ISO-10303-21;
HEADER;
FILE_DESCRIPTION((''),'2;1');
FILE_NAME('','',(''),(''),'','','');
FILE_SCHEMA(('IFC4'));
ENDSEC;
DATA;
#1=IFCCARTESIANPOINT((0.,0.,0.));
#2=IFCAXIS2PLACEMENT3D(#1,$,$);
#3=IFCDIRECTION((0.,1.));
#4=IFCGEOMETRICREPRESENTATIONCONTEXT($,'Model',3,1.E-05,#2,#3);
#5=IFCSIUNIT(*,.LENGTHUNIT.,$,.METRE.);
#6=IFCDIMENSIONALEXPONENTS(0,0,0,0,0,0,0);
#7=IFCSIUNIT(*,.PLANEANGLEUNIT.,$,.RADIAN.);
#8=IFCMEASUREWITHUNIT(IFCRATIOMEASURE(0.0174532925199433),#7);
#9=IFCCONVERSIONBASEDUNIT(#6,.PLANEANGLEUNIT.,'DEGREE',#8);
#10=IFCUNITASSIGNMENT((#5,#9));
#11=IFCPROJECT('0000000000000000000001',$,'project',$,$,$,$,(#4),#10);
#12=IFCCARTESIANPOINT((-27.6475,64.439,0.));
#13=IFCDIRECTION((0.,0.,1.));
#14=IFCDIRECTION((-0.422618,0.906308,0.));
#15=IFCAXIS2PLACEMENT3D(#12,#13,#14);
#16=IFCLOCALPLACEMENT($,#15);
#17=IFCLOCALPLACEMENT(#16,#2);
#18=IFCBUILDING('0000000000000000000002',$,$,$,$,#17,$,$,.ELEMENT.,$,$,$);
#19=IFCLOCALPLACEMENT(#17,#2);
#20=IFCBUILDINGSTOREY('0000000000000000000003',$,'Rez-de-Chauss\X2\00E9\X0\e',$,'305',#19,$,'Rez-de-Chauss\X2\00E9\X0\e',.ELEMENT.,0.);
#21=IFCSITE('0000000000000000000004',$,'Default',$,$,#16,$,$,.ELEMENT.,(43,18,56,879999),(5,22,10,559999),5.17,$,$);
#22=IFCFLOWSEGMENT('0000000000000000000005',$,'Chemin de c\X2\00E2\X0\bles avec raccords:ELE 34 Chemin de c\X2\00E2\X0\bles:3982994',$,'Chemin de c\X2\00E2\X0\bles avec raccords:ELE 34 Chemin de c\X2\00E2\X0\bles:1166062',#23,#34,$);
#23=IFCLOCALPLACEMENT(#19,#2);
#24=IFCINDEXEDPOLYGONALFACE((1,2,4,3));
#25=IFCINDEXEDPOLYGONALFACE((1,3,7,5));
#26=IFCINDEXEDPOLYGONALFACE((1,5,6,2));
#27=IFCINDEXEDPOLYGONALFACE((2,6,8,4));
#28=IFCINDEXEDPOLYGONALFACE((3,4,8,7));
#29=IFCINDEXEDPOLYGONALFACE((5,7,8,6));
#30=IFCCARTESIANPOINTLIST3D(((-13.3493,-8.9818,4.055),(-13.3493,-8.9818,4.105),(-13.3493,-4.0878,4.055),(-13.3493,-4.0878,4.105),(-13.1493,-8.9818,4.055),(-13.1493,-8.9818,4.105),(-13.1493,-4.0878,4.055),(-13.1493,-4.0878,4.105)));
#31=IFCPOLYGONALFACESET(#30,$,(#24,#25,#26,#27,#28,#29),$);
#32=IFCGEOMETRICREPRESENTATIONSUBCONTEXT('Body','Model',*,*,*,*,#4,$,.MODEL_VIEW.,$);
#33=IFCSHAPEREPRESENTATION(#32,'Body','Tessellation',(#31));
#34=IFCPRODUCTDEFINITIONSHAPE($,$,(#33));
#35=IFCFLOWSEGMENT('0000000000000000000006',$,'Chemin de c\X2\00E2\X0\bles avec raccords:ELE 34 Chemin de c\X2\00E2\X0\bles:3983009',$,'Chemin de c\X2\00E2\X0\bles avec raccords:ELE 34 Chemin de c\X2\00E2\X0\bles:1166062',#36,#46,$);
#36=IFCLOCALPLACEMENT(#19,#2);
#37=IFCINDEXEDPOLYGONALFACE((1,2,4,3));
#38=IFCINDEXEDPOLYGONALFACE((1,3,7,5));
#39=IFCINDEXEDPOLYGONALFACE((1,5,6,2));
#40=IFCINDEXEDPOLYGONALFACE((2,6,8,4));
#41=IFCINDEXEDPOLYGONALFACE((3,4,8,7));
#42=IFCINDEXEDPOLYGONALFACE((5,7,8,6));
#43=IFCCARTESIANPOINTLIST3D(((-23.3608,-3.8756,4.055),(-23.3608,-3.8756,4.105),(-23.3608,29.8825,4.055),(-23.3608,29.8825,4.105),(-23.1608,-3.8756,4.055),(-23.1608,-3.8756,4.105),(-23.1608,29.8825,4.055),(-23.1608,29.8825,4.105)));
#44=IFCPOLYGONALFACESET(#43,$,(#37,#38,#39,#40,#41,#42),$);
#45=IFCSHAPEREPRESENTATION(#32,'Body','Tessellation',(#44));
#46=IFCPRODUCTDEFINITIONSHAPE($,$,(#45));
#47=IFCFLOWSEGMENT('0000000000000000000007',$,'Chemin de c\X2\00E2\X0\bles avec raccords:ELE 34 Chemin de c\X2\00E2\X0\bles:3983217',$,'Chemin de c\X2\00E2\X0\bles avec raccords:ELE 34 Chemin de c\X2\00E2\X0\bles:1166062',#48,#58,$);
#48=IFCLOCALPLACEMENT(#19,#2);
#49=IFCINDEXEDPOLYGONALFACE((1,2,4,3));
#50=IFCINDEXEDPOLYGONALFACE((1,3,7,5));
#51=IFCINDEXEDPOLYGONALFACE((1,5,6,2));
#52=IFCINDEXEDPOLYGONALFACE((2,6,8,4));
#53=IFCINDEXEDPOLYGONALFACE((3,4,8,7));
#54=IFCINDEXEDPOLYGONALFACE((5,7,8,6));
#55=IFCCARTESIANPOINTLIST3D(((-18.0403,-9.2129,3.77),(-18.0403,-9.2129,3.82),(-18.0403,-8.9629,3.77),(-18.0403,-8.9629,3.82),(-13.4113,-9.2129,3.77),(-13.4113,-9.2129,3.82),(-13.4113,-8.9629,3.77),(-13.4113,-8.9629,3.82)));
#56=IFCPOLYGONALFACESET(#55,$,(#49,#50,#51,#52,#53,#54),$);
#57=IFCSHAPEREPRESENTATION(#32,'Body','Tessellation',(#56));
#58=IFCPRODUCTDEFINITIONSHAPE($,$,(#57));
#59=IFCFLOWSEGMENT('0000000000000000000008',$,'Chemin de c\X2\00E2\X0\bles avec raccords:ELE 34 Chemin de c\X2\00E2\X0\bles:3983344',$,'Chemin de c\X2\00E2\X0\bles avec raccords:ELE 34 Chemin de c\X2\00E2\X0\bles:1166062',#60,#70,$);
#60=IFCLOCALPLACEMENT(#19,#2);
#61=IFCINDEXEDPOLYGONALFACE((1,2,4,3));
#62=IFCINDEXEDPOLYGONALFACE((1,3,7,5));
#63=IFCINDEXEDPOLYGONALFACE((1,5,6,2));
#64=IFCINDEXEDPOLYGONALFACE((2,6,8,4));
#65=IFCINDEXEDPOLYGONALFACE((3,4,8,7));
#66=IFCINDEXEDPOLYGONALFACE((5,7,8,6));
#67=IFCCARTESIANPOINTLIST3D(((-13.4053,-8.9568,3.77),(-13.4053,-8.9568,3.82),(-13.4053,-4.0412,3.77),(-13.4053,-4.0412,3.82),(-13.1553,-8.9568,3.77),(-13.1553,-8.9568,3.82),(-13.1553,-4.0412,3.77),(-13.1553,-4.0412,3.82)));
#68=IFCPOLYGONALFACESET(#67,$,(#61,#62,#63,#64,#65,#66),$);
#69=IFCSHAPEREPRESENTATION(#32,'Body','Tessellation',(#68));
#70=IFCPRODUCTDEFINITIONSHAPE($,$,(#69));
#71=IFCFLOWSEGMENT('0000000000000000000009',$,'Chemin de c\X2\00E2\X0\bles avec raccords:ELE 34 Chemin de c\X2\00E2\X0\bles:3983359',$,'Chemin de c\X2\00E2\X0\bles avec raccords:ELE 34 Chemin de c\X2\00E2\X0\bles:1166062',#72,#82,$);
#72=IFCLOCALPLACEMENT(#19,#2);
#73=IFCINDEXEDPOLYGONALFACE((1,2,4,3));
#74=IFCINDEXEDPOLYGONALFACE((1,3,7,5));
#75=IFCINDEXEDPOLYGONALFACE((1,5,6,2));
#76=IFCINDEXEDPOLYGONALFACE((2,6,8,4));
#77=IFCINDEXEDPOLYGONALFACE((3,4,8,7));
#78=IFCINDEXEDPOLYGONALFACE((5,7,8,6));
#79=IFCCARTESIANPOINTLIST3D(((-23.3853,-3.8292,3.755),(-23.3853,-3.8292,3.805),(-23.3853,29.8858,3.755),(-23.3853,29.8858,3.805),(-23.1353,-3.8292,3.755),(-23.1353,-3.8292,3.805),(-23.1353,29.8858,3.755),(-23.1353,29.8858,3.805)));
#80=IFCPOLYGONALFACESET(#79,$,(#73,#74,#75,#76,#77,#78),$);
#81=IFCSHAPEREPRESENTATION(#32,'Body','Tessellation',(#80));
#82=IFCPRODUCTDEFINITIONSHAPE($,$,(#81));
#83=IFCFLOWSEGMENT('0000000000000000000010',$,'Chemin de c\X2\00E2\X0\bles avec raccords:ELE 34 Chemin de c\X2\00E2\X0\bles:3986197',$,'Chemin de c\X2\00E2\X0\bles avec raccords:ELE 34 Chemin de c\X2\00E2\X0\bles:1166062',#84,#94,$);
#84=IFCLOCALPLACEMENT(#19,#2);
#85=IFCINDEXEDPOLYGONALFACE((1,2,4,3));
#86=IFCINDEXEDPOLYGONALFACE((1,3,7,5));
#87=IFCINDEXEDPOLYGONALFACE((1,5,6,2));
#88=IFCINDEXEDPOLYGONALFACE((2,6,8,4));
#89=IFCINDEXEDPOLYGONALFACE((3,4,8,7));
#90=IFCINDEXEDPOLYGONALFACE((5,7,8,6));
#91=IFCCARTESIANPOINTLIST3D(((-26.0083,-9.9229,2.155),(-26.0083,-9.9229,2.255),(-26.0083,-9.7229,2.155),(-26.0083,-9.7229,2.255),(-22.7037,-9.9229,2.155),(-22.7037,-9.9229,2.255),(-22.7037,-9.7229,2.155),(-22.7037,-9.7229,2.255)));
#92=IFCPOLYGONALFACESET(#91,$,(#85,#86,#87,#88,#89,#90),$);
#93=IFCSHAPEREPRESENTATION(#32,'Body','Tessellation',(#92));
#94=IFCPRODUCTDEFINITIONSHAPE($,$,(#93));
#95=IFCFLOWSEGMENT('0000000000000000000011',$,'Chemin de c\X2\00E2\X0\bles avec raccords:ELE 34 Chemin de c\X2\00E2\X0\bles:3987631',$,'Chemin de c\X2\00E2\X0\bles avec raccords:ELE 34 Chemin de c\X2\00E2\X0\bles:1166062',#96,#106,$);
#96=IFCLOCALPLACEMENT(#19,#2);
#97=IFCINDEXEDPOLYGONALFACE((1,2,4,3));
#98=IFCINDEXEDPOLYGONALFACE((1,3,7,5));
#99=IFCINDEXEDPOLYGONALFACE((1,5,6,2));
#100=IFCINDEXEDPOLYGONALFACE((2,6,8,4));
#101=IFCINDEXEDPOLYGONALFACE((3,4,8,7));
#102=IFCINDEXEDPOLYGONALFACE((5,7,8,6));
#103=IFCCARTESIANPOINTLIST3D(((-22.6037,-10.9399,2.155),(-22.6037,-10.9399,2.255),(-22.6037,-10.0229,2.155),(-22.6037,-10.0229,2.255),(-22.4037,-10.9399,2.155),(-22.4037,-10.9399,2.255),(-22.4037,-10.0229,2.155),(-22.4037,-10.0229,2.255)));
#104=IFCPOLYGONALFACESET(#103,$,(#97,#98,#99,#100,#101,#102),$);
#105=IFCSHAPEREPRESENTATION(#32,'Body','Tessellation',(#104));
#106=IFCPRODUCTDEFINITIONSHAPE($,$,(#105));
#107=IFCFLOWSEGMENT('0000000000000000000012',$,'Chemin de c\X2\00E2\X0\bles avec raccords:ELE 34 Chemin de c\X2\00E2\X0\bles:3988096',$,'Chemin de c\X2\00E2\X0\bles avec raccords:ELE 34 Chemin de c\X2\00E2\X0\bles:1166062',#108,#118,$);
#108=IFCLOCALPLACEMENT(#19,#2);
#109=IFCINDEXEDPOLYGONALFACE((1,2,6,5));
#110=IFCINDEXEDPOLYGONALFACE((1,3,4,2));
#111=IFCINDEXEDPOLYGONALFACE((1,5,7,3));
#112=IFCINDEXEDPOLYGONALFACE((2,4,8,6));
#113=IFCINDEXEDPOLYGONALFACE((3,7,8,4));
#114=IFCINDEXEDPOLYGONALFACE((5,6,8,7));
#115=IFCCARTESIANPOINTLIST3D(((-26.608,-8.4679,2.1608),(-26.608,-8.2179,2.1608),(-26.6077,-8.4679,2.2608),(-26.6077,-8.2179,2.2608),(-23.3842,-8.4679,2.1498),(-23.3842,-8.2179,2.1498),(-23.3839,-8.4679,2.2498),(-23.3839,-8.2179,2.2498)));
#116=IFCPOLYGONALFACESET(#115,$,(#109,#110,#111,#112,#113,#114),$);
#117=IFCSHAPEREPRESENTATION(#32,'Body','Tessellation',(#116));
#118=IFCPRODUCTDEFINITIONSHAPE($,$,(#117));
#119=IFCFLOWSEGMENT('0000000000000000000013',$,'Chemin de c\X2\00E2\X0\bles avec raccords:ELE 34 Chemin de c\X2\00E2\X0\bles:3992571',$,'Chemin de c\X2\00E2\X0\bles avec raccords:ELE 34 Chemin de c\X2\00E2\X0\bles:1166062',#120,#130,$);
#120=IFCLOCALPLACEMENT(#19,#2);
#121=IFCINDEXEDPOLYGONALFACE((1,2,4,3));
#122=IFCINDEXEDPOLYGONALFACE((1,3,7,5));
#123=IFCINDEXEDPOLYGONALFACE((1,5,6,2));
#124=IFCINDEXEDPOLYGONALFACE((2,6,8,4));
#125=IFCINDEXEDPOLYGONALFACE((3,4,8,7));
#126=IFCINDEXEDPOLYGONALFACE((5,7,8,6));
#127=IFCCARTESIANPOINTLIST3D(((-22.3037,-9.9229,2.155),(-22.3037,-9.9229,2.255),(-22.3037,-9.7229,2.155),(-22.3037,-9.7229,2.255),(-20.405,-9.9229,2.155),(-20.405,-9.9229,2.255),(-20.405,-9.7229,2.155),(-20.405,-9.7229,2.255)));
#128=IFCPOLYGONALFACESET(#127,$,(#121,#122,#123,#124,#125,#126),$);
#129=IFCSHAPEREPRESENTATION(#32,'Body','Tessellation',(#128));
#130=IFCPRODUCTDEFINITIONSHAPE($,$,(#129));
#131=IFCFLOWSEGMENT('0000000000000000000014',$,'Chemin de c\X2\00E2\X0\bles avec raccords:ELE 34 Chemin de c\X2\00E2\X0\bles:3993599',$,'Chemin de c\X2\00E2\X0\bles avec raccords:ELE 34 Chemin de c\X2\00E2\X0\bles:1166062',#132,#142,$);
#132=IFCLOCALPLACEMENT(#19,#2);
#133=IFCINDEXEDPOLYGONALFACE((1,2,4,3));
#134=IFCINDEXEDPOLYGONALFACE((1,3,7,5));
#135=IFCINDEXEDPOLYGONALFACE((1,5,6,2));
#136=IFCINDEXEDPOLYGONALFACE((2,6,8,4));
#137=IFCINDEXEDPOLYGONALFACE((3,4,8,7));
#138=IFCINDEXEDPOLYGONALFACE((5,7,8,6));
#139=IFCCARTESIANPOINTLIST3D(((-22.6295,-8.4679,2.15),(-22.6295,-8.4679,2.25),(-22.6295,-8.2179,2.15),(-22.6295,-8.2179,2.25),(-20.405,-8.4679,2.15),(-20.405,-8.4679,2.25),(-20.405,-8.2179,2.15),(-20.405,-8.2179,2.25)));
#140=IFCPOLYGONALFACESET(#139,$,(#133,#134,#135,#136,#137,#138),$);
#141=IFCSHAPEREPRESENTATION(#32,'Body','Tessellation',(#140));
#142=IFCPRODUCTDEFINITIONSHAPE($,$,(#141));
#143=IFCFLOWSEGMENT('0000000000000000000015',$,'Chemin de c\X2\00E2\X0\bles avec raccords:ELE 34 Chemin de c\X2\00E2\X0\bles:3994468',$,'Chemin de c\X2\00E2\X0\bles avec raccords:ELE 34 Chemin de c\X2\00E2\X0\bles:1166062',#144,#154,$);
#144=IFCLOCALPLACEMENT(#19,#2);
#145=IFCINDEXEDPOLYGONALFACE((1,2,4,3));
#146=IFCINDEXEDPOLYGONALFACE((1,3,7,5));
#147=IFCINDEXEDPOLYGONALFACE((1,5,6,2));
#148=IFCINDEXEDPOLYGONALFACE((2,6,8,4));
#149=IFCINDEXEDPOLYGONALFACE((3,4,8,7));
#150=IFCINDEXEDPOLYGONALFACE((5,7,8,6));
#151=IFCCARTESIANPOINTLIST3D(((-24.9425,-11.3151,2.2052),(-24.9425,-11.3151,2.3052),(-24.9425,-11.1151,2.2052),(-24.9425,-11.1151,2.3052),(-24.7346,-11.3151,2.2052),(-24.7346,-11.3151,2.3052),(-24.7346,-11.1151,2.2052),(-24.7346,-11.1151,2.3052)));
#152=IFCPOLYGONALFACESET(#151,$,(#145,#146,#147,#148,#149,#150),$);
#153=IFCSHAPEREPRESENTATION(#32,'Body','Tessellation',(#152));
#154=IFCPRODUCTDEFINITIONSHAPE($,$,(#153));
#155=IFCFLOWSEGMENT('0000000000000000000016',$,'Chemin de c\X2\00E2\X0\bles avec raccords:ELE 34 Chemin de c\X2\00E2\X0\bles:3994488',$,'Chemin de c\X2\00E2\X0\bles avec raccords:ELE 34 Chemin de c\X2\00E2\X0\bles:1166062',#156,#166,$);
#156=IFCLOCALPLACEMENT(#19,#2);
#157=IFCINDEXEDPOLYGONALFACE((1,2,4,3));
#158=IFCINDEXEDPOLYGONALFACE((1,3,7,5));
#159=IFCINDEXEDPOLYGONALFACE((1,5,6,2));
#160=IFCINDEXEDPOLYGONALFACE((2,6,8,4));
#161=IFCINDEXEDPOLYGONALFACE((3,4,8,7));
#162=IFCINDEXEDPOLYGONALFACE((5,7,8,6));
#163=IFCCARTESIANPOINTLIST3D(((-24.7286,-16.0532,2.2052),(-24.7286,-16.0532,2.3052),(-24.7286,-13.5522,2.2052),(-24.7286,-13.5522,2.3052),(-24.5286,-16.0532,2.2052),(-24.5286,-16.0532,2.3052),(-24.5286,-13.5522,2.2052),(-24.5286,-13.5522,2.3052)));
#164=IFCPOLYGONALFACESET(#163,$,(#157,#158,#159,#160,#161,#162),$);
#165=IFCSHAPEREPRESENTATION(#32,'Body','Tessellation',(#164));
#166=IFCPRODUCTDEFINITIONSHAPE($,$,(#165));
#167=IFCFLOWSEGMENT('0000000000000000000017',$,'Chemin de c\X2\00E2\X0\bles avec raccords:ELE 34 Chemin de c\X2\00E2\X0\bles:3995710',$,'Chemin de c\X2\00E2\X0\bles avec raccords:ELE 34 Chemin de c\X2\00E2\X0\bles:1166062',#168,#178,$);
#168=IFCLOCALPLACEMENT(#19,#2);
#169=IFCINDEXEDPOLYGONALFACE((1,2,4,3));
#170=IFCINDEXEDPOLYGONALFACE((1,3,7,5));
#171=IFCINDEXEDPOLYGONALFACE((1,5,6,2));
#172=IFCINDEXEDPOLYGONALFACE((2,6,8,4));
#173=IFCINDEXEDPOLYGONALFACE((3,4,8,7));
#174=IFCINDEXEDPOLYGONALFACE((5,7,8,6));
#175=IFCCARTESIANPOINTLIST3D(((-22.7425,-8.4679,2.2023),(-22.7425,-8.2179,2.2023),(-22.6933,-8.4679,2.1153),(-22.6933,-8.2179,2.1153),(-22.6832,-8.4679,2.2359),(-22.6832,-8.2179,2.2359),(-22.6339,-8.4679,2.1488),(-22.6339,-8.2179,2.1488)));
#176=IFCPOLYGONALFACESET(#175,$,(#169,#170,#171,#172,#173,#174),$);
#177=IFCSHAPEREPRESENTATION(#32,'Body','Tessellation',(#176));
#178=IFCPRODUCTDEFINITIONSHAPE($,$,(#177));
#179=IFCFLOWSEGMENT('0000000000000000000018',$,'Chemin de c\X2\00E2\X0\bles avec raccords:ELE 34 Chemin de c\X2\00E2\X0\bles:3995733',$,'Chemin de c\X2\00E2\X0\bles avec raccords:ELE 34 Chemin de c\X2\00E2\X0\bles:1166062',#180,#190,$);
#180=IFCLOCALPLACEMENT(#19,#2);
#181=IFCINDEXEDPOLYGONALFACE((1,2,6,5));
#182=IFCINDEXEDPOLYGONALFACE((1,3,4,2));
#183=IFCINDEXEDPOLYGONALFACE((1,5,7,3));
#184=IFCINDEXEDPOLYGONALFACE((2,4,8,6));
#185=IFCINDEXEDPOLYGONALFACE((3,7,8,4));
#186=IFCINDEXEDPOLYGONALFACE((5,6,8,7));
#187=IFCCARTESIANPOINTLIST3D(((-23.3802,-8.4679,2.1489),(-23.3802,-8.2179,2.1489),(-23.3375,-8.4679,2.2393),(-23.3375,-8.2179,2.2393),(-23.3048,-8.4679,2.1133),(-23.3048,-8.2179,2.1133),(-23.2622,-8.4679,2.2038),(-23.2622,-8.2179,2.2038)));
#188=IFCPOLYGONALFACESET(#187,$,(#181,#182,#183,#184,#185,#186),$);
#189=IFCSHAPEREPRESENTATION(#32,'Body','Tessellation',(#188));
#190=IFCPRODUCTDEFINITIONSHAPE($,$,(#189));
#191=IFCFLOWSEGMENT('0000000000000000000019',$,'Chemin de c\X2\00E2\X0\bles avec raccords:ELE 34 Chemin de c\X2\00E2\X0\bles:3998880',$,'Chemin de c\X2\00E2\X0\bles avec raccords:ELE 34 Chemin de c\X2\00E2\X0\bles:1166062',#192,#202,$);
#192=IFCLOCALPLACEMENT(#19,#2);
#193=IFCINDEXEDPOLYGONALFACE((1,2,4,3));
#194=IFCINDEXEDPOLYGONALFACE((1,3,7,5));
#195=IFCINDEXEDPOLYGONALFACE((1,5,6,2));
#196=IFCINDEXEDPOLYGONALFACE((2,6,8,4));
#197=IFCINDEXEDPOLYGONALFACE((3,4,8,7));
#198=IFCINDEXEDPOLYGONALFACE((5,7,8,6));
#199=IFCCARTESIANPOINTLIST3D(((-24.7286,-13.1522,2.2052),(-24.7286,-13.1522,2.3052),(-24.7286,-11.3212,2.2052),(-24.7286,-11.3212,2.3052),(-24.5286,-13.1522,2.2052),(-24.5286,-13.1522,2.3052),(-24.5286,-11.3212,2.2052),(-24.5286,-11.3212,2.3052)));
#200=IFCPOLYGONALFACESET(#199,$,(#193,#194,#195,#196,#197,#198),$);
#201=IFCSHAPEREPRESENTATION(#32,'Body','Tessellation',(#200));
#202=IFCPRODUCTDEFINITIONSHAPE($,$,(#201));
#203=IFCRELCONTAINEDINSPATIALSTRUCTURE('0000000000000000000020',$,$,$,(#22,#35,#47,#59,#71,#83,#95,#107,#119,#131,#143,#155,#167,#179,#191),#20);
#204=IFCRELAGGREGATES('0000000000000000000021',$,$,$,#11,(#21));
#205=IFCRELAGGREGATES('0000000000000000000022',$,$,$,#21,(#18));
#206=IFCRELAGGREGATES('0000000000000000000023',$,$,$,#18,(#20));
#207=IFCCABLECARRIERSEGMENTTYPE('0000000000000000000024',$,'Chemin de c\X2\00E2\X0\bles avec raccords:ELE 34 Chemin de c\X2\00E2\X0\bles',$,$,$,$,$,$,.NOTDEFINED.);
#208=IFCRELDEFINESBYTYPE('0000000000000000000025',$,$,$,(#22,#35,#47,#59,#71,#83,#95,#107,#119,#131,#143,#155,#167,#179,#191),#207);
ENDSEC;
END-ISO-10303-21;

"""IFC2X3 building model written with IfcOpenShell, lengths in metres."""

from ifc_helpers import new_model, entity, si_unit, converted_unit, direction, frame, frame_2d, origin, origin_2d_with_axis, place, context, subcontext, project, spatial, rectangle, extrude, type_object, element, save


model = new_model("IFC2X3")

# Units and contexts
model_context = context("Model", 3, precision=1e-05, world=origin(), true_north=direction((0.0, 1.0)))
body_context = subcontext(model_context, "Body", "Model", "MODEL_VIEW")
ifc_project = project(units=[si_unit("LENGTHUNIT", "METRE"), converted_unit("PLANEANGLEUNIT", "DEGREE", entity("IfcRatioMeasure", 0.0174532925199433), si_unit("PLANEANGLEUNIT", "RADIAN"), dimensions=[0, 0, 0, 0, 0, 0, 0])], contexts=[model_context])

# Site, building, storey
site_placement = place(None, frame((-27.6475, 64.439, 0.0), z_axis=(0.0, 0.0, 1.0), x_axis=(-0.422618, 0.906308, 0.0)))
site = spatial("IfcSite", under=ifc_project, at=site_placement, Name="Default", CompositionType="ELEMENT", RefLatitude=(43, 18, 56, 879999), RefLongitude=(5, 22, 10, 559999), RefElevation=5.17)
building_placement = place(site_placement, origin())
building = spatial("IfcBuilding", under=site, at=building_placement, CompositionType="ELEMENT")
storey_placement = place(building_placement, origin())
storey = spatial("IfcBuildingStorey", under=building, at=storey_placement, Name="Rez-de-Chaussée", ObjectType="305", LongName="Rez-de-Chaussée", CompositionType="ELEMENT", Elevation=0.0)

# Flow segments
cable_carrier_segment_type = type_object("IfcCableCarrierSegmentType", Name="Chemin de câbles avec raccords:ELE 34 Chemin de câbles", PredefinedType="NOTDEFINED")
flow_segment_1_placement = place(storey_placement, origin())
element("IfcFlowSegment", 1, at=flow_segment_1_placement, inside=storey, type_object=cable_carrier_segment_type, Name="Chemin de câbles avec raccords:ELE 34 Chemin de câbles:3982994", ObjectType="Chemin de câbles avec raccords:ELE 34 Chemin de câbles:1166062", context=body_context, shape_type="SweptSolid", body=[
    extrude(rectangle(XDim=4.8941, YDim=0.2, at=frame_2d((0.0, 0.0), x_axis=(1.0, 0.0))), frame((-13.2493, -6.5348, 4.055), z_axis=(0.0, 0.0, 1.0), x_axis=(0.0, -1.0, 0.0)), (0.0, 0.0, 1.0), 0.05),
])
flow_segment_2_placement = place(storey_placement, origin())
element("IfcFlowSegment", 2, at=flow_segment_2_placement, inside=storey, type_object=cable_carrier_segment_type, Name="Chemin de câbles avec raccords:ELE 34 Chemin de câbles:3983009", ObjectType="Chemin de câbles avec raccords:ELE 34 Chemin de câbles:1166062", context=body_context, shape_type="SweptSolid", body=[
    extrude(rectangle(XDim=33.7581, YDim=0.2, at=origin_2d_with_axis()), frame((-23.2608, 13.0034, 4.055), z_axis=(0.0, 0.0, 1.0), x_axis=(0.0, 1.0, 0.0)), (0.0, 0.0, 1.0), 0.05),
])
flow_segment_3_placement = place(storey_placement, origin())
element("IfcFlowSegment", 3, at=flow_segment_3_placement, inside=storey, type_object=cable_carrier_segment_type, Name="Chemin de câbles avec raccords:ELE 34 Chemin de câbles:3983217", ObjectType="Chemin de câbles avec raccords:ELE 34 Chemin de câbles:1166062", context=body_context, shape_type="SweptSolid", body=[
    extrude(rectangle(XDim=4.629, YDim=0.25, at=frame_2d((0.0, 0.0), x_axis=(1.0, 0.0))), frame((-15.7258, -9.0879, 3.77), z_axis=(0.0, 0.0, 1.0), x_axis=(-1.0, 0.0, 0.0)), (0.0, 0.0, 1.0), 0.05),
])
flow_segment_4_placement = place(storey_placement, origin())
element("IfcFlowSegment", 4, at=flow_segment_4_placement, inside=storey, type_object=cable_carrier_segment_type, Name="Chemin de câbles avec raccords:ELE 34 Chemin de câbles:3983344", ObjectType="Chemin de câbles avec raccords:ELE 34 Chemin de câbles:1166062", context=body_context, shape_type="SweptSolid", body=[
    extrude(rectangle(XDim=4.9156, YDim=0.25, at=frame_2d((0.0, 0.0), x_axis=(1.0, 0.0))), frame((-13.2803, -6.499, 3.77), z_axis=(0.0, 0.0, 1.0), x_axis=(0.0, 1.0, 0.0)), (0.0, 0.0, 1.0), 0.05),
])
flow_segment_5_placement = place(storey_placement, origin())
element("IfcFlowSegment", 5, at=flow_segment_5_placement, inside=storey, type_object=cable_carrier_segment_type, Name="Chemin de câbles avec raccords:ELE 34 Chemin de câbles:3983359", ObjectType="Chemin de câbles avec raccords:ELE 34 Chemin de câbles:1166062", context=body_context, shape_type="SweptSolid", body=[
    extrude(rectangle(XDim=33.715, YDim=0.25, at=frame_2d((0.0, 0.0), x_axis=(1.0, 0.0))), frame((-23.2603, 13.0283, 3.755), z_axis=(0.0, 0.0, 1.0), x_axis=(0.0, 1.0, 0.0)), (0.0, 0.0, 1.0), 0.05),
])
flow_segment_6_placement = place(storey_placement, origin())
element("IfcFlowSegment", 6, at=flow_segment_6_placement, inside=storey, type_object=cable_carrier_segment_type, Name="Chemin de câbles avec raccords:ELE 34 Chemin de câbles:3986197", ObjectType="Chemin de câbles avec raccords:ELE 34 Chemin de câbles:1166062", context=body_context, shape_type="SweptSolid", body=[
    extrude(rectangle(XDim=3.3046, YDim=0.2, at=frame_2d((0.0, 0.0), x_axis=(1.0, 0.0))), frame((-24.356, -9.8229, 2.155), z_axis=(0.0, 0.0, 1.0), x_axis=(-1.0, 0.0, 0.0)), (0.0, 0.0, 1.0), 0.1),
])
flow_segment_7_placement = place(storey_placement, origin())
element("IfcFlowSegment", 7, at=flow_segment_7_placement, inside=storey, type_object=cable_carrier_segment_type, Name="Chemin de câbles avec raccords:ELE 34 Chemin de câbles:3987631", ObjectType="Chemin de câbles avec raccords:ELE 34 Chemin de câbles:1166062", context=body_context, shape_type="SweptSolid", body=[
    extrude(rectangle(XDim=0.917, YDim=0.2, at=origin_2d_with_axis()), frame((-22.5037, -10.4814, 2.155), z_axis=(0.0, 0.0, 1.0), x_axis=(0.0, -1.0, 0.0)), (0.0, 0.0, 1.0), 0.1),
])
flow_segment_8_placement = place(storey_placement, origin())
element("IfcFlowSegment", 8, at=flow_segment_8_placement, inside=storey, type_object=cable_carrier_segment_type, Name="Chemin de câbles avec raccords:ELE 34 Chemin de câbles:3988096", ObjectType="Chemin de câbles avec raccords:ELE 34 Chemin de câbles:1166062", context=body_context, shape_type="SweptSolid", body=[
    extrude(rectangle(XDim=3.2238, YDim=0.25, at=frame_2d((0.0, 0.0), x_axis=(1.0, 0.0))), frame((-24.9961, -8.3429, 2.1553), z_axis=(0.003393, 0.0, 0.999994), x_axis=(-0.999994, 0.0, 0.003393)), (0.0, 0.0, 1.0), 0.1),
])
flow_segment_9_placement = place(storey_placement, origin())
element("IfcFlowSegment", 9, at=flow_segment_9_placement, inside=storey, type_object=cable_carrier_segment_type, Name="Chemin de câbles avec raccords:ELE 34 Chemin de câbles:3992571", ObjectType="Chemin de câbles avec raccords:ELE 34 Chemin de câbles:1166062", context=body_context, shape_type="SweptSolid", body=[
    extrude(rectangle(XDim=1.8987, YDim=0.2, at=frame_2d((0.0, 0.0), x_axis=(1.0, 0.0))), frame((-21.3544, -9.8229, 2.155)), (0.0, 0.0, 1.0), 0.1),
])
flow_segment_10_placement = place(storey_placement, origin())
element("IfcFlowSegment", 10, at=flow_segment_10_placement, inside=storey, type_object=cable_carrier_segment_type, Name="Chemin de câbles avec raccords:ELE 34 Chemin de câbles:3993599", ObjectType="Chemin de câbles avec raccords:ELE 34 Chemin de câbles:1166062", context=body_context, shape_type="SweptSolid", body=[
    extrude(rectangle(XDim=2.2245, YDim=0.25, at=frame_2d((0.0, 0.0), x_axis=(1.0, 0.0))), frame((-21.5173, -8.3429, 2.15)), (0.0, 0.0, 1.0), 0.1),
])
flow_segment_11_placement = place(storey_placement, origin())
element("IfcFlowSegment", 11, at=flow_segment_11_placement, inside=storey, type_object=cable_carrier_segment_type, Name="Chemin de câbles avec raccords:ELE 34 Chemin de câbles:3994468", ObjectType="Chemin de câbles avec raccords:ELE 34 Chemin de câbles:1166062", context=body_context, shape_type="SweptSolid", body=[
    extrude(rectangle(XDim=0.2078, YDim=0.2, at=frame_2d((0.0, 0.0), x_axis=(1.0, 0.0))), frame((-24.8386, -11.2151, 2.2052)), (0.0, 0.0, 1.0), 0.1),
])
flow_segment_12_placement = place(storey_placement, origin())
element("IfcFlowSegment", 12, at=flow_segment_12_placement, inside=storey, type_object=cable_carrier_segment_type, Name="Chemin de câbles avec raccords:ELE 34 Chemin de câbles:3994488", ObjectType="Chemin de câbles avec raccords:ELE 34 Chemin de câbles:1166062", context=body_context, shape_type="SweptSolid", body=[
    extrude(rectangle(XDim=2.5009, YDim=0.2, at=frame_2d((0.0, 0.0), x_axis=(1.0, 0.0))), frame((-24.6286, -14.8027, 2.2052), z_axis=(0.0, 0.0, 1.0), x_axis=(0.0, -1.0, 0.0)), (0.0, 0.0, 1.0), 0.1),
])
flow_segment_13_placement = place(storey_placement, origin())
element("IfcFlowSegment", 13, at=flow_segment_13_placement, inside=storey, type_object=cable_carrier_segment_type, Name="Chemin de câbles avec raccords:ELE 34 Chemin de câbles:3995710", ObjectType="Chemin de câbles avec raccords:ELE 34 Chemin de câbles:1166062", context=body_context, shape_type="SweptSolid", body=[
    extrude(rectangle(XDim=0.1, YDim=0.0682, at=frame_2d((0.0, 0.0), x_axis=(0.0, 1.0))), frame((-22.6882, -8.4679, 2.1756), z_axis=(0.0, 1.0, 0.0), x_axis=(0.870359, 0.0, 0.492418)), (0.0, 0.0, 1.0), 0.25),
])
flow_segment_14_placement = place(storey_placement, origin())
element("IfcFlowSegment", 14, at=flow_segment_14_placement, inside=storey, type_object=cable_carrier_segment_type, Name="Chemin de câbles avec raccords:ELE 34 Chemin de câbles:3995733", ObjectType="Chemin de câbles avec raccords:ELE 34 Chemin de câbles:1166062", context=body_context, shape_type="SweptSolid", body=[
    extrude(rectangle(XDim=0.1, YDim=0.0833, at=frame_2d((0.0, 0.0), x_axis=(0.0, 1.0))), frame((-23.3212, -8.4679, 2.1763), z_axis=(0.0, 1.0, 0.0), x_axis=(0.904361, 0.0, -0.426769)), (0.0, 0.0, 1.0), 0.25),
])
flow_segment_15_placement = place(storey_placement, origin())
element("IfcFlowSegment", 15, at=flow_segment_15_placement, inside=storey, type_object=cable_carrier_segment_type, Name="Chemin de câbles avec raccords:ELE 34 Chemin de câbles:3998880", ObjectType="Chemin de câbles avec raccords:ELE 34 Chemin de câbles:1166062", context=body_context, shape_type="SweptSolid", body=[
    extrude(rectangle(XDim=1.831, YDim=0.2, at=origin_2d_with_axis()), frame((-24.6286, -12.2367, 2.2052), z_axis=(0.0, 0.0, 1.0), x_axis=(0.0, -1.0, 0.0)), (0.0, 0.0, 1.0), 0.1),
])

save(model, "model.ifc")
